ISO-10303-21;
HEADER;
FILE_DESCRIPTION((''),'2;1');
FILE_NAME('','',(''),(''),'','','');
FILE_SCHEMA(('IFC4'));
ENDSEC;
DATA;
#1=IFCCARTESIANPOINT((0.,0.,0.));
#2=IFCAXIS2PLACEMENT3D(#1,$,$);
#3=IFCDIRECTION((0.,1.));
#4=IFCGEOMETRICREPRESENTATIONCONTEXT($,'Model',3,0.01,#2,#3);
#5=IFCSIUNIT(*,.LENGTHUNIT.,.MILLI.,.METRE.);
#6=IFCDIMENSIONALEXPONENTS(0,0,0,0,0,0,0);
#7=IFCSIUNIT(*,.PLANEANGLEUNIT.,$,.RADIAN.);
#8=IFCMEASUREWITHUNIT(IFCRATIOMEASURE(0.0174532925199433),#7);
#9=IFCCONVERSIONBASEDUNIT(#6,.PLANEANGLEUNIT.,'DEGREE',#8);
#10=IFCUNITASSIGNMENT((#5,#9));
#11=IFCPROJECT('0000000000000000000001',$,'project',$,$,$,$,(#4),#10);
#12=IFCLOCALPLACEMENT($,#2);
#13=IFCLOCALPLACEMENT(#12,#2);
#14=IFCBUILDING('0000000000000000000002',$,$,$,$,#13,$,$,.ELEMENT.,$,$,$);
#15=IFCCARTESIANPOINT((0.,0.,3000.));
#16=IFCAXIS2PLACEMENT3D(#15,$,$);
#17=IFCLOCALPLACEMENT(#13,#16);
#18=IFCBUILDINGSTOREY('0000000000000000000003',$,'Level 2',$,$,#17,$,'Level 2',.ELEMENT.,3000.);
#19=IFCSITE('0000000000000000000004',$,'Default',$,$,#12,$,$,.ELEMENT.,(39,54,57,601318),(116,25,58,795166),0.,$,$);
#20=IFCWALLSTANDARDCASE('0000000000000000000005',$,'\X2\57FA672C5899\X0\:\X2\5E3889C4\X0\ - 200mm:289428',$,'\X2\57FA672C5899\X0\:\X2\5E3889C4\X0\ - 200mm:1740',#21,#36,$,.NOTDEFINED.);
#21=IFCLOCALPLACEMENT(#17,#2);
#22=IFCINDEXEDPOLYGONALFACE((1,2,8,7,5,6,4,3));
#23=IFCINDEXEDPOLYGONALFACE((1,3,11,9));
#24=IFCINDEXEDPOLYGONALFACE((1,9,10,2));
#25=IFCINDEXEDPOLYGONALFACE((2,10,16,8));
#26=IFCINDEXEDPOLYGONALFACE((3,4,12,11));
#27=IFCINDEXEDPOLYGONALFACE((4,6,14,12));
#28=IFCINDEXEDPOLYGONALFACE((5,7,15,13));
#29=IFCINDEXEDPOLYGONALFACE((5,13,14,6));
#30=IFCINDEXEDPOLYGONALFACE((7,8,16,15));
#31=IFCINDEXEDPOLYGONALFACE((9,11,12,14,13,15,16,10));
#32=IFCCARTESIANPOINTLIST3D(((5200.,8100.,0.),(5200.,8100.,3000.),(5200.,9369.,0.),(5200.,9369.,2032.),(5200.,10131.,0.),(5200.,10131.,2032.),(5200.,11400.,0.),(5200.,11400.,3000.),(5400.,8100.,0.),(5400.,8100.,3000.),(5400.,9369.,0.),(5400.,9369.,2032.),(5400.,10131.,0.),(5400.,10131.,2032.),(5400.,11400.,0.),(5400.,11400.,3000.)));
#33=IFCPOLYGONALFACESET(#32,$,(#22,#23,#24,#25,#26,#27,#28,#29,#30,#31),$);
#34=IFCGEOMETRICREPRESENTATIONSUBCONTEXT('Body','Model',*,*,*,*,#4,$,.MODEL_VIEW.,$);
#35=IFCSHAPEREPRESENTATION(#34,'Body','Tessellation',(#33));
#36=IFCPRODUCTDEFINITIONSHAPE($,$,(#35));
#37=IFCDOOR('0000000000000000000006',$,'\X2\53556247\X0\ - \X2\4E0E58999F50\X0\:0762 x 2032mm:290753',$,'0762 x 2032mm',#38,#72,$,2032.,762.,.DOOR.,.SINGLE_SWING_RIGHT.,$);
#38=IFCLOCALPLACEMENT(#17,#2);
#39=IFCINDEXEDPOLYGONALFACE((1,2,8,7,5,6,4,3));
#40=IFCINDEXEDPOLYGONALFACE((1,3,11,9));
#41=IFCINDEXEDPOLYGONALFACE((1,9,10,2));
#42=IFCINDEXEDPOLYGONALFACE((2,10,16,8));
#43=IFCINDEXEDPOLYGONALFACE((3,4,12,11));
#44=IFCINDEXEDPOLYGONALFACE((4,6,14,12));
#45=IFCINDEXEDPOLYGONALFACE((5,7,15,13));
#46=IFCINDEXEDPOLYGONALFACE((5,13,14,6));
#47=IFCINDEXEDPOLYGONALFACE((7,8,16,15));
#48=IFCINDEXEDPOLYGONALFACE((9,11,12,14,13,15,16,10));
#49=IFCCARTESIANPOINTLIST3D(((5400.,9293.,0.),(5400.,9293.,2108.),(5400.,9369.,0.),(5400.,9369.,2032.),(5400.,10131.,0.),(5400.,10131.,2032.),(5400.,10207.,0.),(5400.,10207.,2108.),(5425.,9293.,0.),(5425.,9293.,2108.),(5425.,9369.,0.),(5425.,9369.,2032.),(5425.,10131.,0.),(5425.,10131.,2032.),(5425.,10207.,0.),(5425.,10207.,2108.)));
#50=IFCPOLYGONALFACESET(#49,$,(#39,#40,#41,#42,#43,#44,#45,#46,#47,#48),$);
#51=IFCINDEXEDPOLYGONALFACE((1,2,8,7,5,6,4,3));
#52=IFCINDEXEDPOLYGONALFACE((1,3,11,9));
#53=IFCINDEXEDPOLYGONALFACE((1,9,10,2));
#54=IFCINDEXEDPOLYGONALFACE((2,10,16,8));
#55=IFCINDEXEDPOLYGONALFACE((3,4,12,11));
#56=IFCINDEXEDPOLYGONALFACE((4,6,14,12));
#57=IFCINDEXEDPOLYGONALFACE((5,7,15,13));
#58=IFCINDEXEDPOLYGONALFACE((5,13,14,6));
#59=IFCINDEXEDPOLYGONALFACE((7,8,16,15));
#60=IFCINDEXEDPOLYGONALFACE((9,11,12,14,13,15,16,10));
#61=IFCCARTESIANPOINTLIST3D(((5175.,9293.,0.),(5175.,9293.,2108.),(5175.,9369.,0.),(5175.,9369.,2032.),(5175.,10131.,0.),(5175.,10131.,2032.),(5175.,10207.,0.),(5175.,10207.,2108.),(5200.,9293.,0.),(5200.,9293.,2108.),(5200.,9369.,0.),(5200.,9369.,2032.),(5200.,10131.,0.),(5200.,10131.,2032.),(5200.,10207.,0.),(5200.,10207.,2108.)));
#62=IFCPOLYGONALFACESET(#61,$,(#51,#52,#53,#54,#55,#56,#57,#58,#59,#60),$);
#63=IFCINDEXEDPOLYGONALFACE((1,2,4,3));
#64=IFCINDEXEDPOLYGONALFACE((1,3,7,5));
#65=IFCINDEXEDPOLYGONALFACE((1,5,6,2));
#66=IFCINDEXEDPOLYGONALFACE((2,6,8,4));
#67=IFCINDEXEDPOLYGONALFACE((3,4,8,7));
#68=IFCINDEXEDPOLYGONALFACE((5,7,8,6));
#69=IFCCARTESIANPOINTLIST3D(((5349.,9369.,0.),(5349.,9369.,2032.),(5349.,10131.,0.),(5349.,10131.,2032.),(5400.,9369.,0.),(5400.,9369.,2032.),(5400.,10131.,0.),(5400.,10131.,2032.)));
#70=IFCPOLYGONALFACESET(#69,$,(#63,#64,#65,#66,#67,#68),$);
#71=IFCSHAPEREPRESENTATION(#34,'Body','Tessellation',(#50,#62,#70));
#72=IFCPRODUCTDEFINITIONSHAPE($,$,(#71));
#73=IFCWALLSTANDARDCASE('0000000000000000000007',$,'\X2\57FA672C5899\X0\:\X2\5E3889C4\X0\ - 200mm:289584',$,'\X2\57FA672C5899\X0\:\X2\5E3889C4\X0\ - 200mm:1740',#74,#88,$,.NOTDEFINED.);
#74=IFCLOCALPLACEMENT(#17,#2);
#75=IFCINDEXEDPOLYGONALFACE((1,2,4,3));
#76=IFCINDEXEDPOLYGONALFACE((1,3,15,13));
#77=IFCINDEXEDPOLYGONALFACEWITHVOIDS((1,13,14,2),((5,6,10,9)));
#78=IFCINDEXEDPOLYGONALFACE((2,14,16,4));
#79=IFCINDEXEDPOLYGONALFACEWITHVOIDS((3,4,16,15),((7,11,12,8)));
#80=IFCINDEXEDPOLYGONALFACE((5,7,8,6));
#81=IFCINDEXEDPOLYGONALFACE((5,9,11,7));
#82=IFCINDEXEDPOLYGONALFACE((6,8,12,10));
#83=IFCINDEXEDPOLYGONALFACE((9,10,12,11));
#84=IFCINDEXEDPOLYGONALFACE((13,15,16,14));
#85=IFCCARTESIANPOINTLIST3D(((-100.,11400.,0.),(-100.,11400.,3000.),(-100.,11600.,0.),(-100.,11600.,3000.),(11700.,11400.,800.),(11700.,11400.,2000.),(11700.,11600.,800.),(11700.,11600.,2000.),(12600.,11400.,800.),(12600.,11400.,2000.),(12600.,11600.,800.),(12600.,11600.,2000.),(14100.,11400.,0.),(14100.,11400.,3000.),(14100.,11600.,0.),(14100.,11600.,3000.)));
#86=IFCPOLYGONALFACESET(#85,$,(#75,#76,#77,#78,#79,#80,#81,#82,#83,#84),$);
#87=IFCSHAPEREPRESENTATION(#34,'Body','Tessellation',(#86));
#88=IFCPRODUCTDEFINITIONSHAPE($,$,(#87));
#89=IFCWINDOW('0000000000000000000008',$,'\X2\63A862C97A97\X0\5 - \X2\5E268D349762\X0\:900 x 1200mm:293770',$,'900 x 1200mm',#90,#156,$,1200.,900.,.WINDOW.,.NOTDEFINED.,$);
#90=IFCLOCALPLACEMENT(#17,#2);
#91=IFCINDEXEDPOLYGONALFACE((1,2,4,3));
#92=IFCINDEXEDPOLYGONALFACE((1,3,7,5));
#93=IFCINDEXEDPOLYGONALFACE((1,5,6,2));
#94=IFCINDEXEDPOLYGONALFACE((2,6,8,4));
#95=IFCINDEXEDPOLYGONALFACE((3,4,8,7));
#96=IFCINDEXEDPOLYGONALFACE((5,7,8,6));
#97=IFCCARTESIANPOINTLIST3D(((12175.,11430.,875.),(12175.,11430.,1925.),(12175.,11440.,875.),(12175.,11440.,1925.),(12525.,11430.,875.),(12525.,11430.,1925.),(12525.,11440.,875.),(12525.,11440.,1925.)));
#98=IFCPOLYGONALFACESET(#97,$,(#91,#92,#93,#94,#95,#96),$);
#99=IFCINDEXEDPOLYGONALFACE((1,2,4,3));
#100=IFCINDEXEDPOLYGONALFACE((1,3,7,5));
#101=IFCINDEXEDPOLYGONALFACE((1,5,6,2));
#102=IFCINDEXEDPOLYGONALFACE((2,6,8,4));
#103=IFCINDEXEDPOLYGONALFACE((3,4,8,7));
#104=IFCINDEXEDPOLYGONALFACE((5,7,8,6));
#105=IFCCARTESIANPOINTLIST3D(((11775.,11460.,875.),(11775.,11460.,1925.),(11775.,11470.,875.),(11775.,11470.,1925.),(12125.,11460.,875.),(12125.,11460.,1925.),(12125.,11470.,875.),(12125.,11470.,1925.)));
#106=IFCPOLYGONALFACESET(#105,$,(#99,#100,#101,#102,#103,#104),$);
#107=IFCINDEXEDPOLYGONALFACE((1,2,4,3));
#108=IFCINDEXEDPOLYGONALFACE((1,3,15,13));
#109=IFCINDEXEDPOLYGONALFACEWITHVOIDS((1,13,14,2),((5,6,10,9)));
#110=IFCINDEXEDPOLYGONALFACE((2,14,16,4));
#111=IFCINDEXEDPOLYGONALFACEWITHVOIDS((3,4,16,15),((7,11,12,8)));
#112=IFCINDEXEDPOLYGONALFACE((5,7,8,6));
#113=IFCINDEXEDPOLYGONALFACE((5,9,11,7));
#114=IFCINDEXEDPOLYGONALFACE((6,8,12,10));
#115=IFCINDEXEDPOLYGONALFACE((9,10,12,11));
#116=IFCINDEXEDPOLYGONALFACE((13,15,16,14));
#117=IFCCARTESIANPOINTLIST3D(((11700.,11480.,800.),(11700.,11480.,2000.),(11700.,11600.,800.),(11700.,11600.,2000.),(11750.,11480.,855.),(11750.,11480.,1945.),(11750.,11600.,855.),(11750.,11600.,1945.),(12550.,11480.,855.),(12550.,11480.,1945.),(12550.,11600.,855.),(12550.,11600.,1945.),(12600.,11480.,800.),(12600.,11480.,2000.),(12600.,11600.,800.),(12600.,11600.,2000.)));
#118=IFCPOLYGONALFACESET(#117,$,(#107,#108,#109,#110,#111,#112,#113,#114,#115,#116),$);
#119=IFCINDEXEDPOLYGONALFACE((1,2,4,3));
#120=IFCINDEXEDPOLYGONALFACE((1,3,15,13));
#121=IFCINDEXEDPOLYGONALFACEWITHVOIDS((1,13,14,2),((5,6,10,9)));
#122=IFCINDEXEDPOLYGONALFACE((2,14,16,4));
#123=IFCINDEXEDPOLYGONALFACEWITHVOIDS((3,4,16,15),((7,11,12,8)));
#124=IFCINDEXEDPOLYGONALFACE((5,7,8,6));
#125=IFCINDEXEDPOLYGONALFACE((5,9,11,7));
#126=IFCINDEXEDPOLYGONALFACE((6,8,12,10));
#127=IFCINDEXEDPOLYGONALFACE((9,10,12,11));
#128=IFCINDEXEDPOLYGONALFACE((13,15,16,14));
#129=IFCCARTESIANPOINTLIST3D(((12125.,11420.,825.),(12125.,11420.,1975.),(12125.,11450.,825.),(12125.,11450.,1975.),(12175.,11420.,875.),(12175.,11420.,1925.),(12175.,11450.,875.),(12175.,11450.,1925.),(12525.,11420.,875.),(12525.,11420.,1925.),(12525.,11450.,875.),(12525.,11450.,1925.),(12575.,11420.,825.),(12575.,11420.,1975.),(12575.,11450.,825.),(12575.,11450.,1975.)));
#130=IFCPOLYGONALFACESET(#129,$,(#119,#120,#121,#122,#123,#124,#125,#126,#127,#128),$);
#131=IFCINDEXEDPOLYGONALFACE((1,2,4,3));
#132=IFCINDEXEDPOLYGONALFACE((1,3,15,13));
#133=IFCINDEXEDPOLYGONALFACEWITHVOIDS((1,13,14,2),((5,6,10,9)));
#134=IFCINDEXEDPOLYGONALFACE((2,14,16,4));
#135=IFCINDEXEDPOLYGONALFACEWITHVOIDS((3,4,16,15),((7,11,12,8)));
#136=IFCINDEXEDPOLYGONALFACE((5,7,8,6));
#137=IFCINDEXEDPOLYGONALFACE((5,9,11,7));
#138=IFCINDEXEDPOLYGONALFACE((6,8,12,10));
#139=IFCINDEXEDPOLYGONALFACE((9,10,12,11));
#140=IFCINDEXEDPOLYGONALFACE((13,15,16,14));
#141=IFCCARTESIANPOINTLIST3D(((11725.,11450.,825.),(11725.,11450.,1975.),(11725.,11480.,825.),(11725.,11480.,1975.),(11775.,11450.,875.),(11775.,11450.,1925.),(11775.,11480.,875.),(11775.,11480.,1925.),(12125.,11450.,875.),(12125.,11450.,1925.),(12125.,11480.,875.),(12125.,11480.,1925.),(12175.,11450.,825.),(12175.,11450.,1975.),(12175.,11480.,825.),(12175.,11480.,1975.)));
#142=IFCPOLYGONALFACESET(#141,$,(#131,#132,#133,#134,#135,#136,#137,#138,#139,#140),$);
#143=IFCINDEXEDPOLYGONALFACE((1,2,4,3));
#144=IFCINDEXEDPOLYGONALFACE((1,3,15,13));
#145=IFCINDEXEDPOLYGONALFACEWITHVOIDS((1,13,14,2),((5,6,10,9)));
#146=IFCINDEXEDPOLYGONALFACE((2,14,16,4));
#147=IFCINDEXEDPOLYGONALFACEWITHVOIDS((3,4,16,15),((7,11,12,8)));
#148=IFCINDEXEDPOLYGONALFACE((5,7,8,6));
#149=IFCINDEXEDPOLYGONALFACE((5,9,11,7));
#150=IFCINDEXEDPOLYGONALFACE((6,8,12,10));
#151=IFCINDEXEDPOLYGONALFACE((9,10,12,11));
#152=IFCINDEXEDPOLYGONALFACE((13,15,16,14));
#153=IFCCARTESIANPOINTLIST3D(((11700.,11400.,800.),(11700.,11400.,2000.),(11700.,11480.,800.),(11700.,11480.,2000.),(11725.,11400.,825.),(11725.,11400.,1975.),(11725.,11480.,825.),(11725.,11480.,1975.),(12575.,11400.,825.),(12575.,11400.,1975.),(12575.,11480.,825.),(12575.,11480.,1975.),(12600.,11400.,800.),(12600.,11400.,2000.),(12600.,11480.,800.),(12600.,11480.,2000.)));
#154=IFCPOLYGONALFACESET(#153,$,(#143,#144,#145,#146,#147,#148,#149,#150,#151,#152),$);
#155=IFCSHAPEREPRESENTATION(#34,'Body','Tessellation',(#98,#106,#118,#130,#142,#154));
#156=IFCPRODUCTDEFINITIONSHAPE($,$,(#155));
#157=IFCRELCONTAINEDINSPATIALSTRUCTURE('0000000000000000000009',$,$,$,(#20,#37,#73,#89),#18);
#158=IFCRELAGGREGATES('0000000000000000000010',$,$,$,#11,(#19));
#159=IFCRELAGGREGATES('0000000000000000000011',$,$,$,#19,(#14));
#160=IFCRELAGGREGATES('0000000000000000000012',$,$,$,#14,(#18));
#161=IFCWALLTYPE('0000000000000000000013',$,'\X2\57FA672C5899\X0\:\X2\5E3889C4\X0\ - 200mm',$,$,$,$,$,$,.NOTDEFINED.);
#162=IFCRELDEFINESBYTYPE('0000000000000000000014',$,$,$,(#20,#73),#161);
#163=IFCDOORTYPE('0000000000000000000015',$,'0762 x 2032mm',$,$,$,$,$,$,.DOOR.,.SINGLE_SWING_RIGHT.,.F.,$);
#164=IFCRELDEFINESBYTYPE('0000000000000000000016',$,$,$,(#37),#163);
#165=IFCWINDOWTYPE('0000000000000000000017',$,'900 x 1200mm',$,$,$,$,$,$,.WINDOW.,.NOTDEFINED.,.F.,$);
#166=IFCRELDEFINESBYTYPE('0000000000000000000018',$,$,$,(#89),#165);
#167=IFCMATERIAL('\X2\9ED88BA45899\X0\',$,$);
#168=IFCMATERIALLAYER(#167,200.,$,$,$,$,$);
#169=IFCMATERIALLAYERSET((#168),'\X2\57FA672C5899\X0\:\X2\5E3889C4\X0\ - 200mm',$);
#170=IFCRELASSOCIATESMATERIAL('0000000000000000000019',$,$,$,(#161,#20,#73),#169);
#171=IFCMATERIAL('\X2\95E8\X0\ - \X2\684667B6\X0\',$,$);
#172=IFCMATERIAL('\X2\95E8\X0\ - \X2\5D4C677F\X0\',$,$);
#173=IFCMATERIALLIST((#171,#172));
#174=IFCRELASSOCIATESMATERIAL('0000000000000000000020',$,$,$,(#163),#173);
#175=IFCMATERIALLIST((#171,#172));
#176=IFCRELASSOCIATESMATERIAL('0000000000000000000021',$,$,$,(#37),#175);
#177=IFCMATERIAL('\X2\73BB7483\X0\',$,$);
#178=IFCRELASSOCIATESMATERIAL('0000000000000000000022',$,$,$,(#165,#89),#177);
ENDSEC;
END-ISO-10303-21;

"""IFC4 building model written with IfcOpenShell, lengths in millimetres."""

from ifc_helpers import new_model, entity, si_unit, converted_unit, direction, frame, frame_2d, origin, origin_2d_with_axis, place, context, subcontext, project, spatial, polyline, rectangle, outline, extrude, source, transform, mapped, material, material_list, layer, layer_set, layer_usage, type_object, type_shapes, element, fill, save


model = new_model("IFC4")

# Units and contexts
model_context = context("Model", 3, precision=0.01, world=origin(), true_north=direction((0.0, 1.0)))
body_context = subcontext(model_context, "Body", "Model", "MODEL_VIEW")
ifc_project = project(units=[si_unit("LENGTHUNIT", "METRE", prefix="MILLI"), converted_unit("PLANEANGLEUNIT", "DEGREE", entity("IfcRatioMeasure", 0.0174532925199433), si_unit("PLANEANGLEUNIT", "RADIAN"), dimensions=[0, 0, 0, 0, 0, 0, 0])], contexts=[model_context])

# Site, building, storey
site_placement = place(None, origin())
site = spatial("IfcSite", under=ifc_project, at=site_placement, Name="Default", CompositionType="ELEMENT", RefLatitude=(39, 54, 57, 601318), RefLongitude=(116, 25, 58, 795166), RefElevation=0.0)
building_placement = place(site_placement, origin())
building = spatial("IfcBuilding", under=site, at=building_placement, CompositionType="ELEMENT")
storey_placement = place(building_placement, frame((0.0, 0.0, 3000.0)))
storey = spatial("IfcBuildingStorey", under=building, at=storey_placement, Name="Level 2", LongName="Level 2", CompositionType="ELEMENT", Elevation=3000.0)

# Shared definitions
ifc_material_1 = material(Name="默认墙")
ifc_layer_1 = layer(ifc_material_1, 200.0)
ifc_layer_set_1 = layer_set([ifc_layer_1], Name="基本墙:常规 - 200mm")
wall_type = type_object("IfcWallType", Name="基本墙:常规 - 200mm", PredefinedType="NOTDEFINED", material=ifc_layer_set_1)

# Wall, opening, door
ifc_layer_usage_1 = layer_usage(ifc_layer_set_1, "AXIS2", "NEGATIVE", 100.0)
wall_1_placement = place(storey_placement, frame((5300.0, 8100.0, 0.0), z_axis=(0.0, 0.0, 1.0), x_axis=(0.0, 1.0, 0.0)))
wall_1 = element("IfcWallStandardCase", 1, at=wall_1_placement, inside=storey, type_object=wall_type, material=ifc_layer_usage_1, Name="基本墙:常规 - 200mm:289428", ObjectType="基本墙:常规 - 200mm:1740", PredefinedType="NOTDEFINED", context=body_context, shape_type="SweptSolid", body=[
    extrude(rectangle(XDim=3300.0, YDim=200.0, at=frame_2d((1650.0, 0.0), x_axis=(-1.0, 0.0))), origin(), (0.0, 0.0, 1.0), 3000.0),
])
opening_1_placement = place(wall_1_placement, frame((2031.0, 100.0, 0.0)))
opening_1 = element("IfcOpeningElement", 2, at=opening_1_placement, cuts=wall_1, ObjectType="Opening", PredefinedType="OPENING", context=body_context, shape_type="SweptSolid", body=[
    extrude(rectangle(XDim=762.0, YDim=2032.0, at=frame_2d((1016.0, 381.0), x_axis=(0.0, 1.0))), frame((0.0, 0.0, 0.0), z_axis=(0.0, -1.0, 0.0), x_axis=(0.0, 0.0, 1.0)), (0.0, 0.0, 1.0), 200.0),
])
ifc_material_2 = material(Name="门 - 框架")
ifc_material_3 = material(Name="门 - 嵌板")
ifc_material_list_1 = material_list([ifc_material_2, ifc_material_3])
ifc_material_list_2 = material_list([ifc_material_2, ifc_material_3])
door_type = type_object("IfcDoorType", Name="0762 x 2032mm", OperationType="SINGLE_SWING_RIGHT", ParameterTakesPrecedence=False, PredefinedType="DOOR", material=ifc_material_list_2)
shared_shape_1 = source(origin(), body_context, "Body", "SweptSolid", [
    extrude(outline(polyline([(-457.0, -1073.0), (457.0, -1073.0), (457.0, 1035.0), (381.0, 1035.0), (381.0, -997.0), (-381.0, -997.0), (-381.0, 1035.0), (-457.0, 1035.0), (-457.0, -1073.0)])), frame((381.0, 200.0, 1035.0), z_axis=(0.0, 1.0, 0.0), x_axis=(1.0, 0.0, 0.0)), (0.0, 0.0, 1.0), 25.0),
    extrude(outline(polyline([(-1073.0, -457.0), (1035.0, -457.0), (1035.0, -381.0), (-997.0, -381.0), (-997.0, 381.0), (1035.0, 381.0), (1035.0, 457.0), (-1073.0, 457.0), (-1073.0, -457.0)])), frame((381.0, -25.0, 1035.0), z_axis=(0.0, 1.0, 0.0), x_axis=(0.0, 0.0, -1.0)), (0.0, 0.0, 1.0), 25.0),
    extrude(rectangle(XDim=51.0, YDim=762.0, at=origin_2d_with_axis()), frame((381.0, 174.5, 0.0), z_axis=(0.0, 0.0, 1.0), x_axis=(0.0, 1.0, 0.0)), (0.0, 0.0, 1.0), 2032.0),
])
type_shapes(door_type, [shared_shape_1])
door_placement = place(opening_1_placement, frame((0.0, 0.0, 0.0), z_axis=(0.0, 0.0, 1.0), x_axis=(-1.0, 0.0, 0.0)))
door = element("IfcDoor", 3, at=door_placement, inside=storey, type_object=door_type, material=ifc_material_list_1, Name="单扇 - 与墙齐:0762 x 2032mm:290753", ObjectType="0762 x 2032mm", OperationType="SINGLE_SWING_RIGHT", OverallHeight=2032.0, OverallWidth=762.0, PredefinedType="DOOR", context=body_context, shape_type="MappedRepresentation", body=[
    mapped(shared_shape_1, transform((0.0, 0.0, 0.0), scale=1.0)),
])
fill(opening_1, door)

# Wall, opening, window
ifc_layer_usage_2 = layer_usage(ifc_layer_set_1, "AXIS2", "NEGATIVE", 100.0)
wall_2_placement = place(storey_placement, frame((-100.0, 11500.0, 0.0)))
wall_2 = element("IfcWallStandardCase", 4, at=wall_2_placement, inside=storey, type_object=wall_type, material=ifc_layer_usage_2, Name="基本墙:常规 - 200mm:289584", ObjectType="基本墙:常规 - 200mm:1740", PredefinedType="NOTDEFINED", context=body_context, shape_type="SweptSolid", body=[
    extrude(rectangle(XDim=14200.0, YDim=200.0, at=frame_2d((7100.0, 0.0), x_axis=(-1.0, 0.0))), origin(), (0.0, 0.0, 1.0), 3000.0),
])
opening_2_placement = place(wall_2_placement, frame((12700.0, 100.0, 800.0)))
opening_2 = element("IfcOpeningElement", 5, at=opening_2_placement, cuts=wall_2, ObjectType="Opening", PredefinedType="OPENING", context=body_context, shape_type="SweptSolid", body=[
    extrude(rectangle(XDim=1200.0, YDim=900.0, at=frame_2d((600.0, 450.0), x_axis=(-1.0, 0.0))), frame((0.0, 0.0, 0.0), z_axis=(0.0, -1.0, 0.0), x_axis=(0.0, 0.0, 1.0)), (0.0, 0.0, 1.0), 200.0),
])
ifc_material_4 = material(Name="玻璃")
window_type = type_object("IfcWindowType", Name="900 x 1200mm", ParameterTakesPrecedence=False, PartitioningType="NOTDEFINED", PredefinedType="WINDOW", material=ifc_material_4)
shared_shape_2 = source(origin(), body_context, "Body", "SweptSolid", [
    extrude(rectangle(XDim=10.0, YDim=350.0, at=origin_2d_with_axis()), frame((250.0, 165.0, 75.0), z_axis=(0.0, 0.0, 1.0), x_axis=(0.0, -1.0, 0.0)), (0.0, 0.0, 1.0), 1050.0),
    extrude(rectangle(XDim=10.0, YDim=350.0, at=origin_2d_with_axis()), frame((650.0, 135.0, 75.0), z_axis=(0.0, 0.0, 1.0), x_axis=(0.0, -1.0, 0.0)), (0.0, 0.0, 1.0), 1050.0),
    extrude(outline(polyline([(-450.0, -600.0), (450.0, -600.0), (450.0, 600.0), (-450.0, 600.0), (-450.0, -600.0)]), holes=[polyline([(400.0, -545.0), (-400.0, -545.0), (-400.0, 545.0), (400.0, 545.0), (400.0, -545.0)])]), frame((450.0, 0.0, 600.0), z_axis=(0.0, 1.0, 0.0), x_axis=(1.0, 0.0, 0.0)), (0.0, 0.0, 1.0), 120.0),
    extrude(outline(polyline([(-225.0, -575.0), (225.0, -575.0), (225.0, 575.0), (-225.0, 575.0), (-225.0, -575.0)]), holes=[polyline([(-175.0, -525.0), (-175.0, 525.0), (175.0, 525.0), (175.0, -525.0), (-175.0, -525.0)])]), frame((250.0, 150.0, 600.0), z_axis=(0.0, 1.0, 0.0), x_axis=(-1.0, 0.0, 0.0)), (0.0, 0.0, 1.0), 30.0),
    extrude(outline(polyline([(-225.0, -575.0), (225.0, -575.0), (225.0, 575.0), (-225.0, 575.0), (-225.0, -575.0)]), holes=[polyline([(-175.0, -525.0), (-175.0, 525.0), (175.0, 525.0), (175.0, -525.0), (-175.0, -525.0)])]), frame((650.0, 120.0, 600.0), z_axis=(0.0, 1.0, 0.0), x_axis=(1.0, 0.0, 0.0)), (0.0, 0.0, 1.0), 30.0),
    extrude(outline(polyline([(-450.0, -600.0), (450.0, -600.0), (450.0, 600.0), (-450.0, 600.0), (-450.0, -600.0)]), holes=[polyline([(-425.0, 575.0), (425.0, 575.0), (425.0, -575.0), (-425.0, -575.0), (-425.0, 575.0)])]), frame((450.0, 120.0, 600.0), z_axis=(0.0, 1.0, 0.0), x_axis=(1.0, 0.0, 0.0)), (0.0, 0.0, 1.0), 80.0),
])
type_shapes(window_type, [shared_shape_2])
window_1_placement = place(opening_2_placement, frame((0.0, 0.0, 0.0), z_axis=(0.0, 0.0, 1.0), x_axis=(-1.0, 0.0, 0.0)))
window_1 = element("IfcWindow", 6, at=window_1_placement, inside=storey, type_object=window_type, material=ifc_material_4, Name="推拉窗5 - 带贴面:900 x 1200mm:293770", ObjectType="900 x 1200mm", OverallHeight=1200.0, OverallWidth=900.0, PartitioningType="NOTDEFINED", PredefinedType="WINDOW", context=body_context, shape_type="MappedRepresentation", body=[
    mapped(shared_shape_2, transform((0.0, 0.0, 0.0), scale=1.0)),
])
fill(opening_2, window_1)

save(model, "model.ifc")
